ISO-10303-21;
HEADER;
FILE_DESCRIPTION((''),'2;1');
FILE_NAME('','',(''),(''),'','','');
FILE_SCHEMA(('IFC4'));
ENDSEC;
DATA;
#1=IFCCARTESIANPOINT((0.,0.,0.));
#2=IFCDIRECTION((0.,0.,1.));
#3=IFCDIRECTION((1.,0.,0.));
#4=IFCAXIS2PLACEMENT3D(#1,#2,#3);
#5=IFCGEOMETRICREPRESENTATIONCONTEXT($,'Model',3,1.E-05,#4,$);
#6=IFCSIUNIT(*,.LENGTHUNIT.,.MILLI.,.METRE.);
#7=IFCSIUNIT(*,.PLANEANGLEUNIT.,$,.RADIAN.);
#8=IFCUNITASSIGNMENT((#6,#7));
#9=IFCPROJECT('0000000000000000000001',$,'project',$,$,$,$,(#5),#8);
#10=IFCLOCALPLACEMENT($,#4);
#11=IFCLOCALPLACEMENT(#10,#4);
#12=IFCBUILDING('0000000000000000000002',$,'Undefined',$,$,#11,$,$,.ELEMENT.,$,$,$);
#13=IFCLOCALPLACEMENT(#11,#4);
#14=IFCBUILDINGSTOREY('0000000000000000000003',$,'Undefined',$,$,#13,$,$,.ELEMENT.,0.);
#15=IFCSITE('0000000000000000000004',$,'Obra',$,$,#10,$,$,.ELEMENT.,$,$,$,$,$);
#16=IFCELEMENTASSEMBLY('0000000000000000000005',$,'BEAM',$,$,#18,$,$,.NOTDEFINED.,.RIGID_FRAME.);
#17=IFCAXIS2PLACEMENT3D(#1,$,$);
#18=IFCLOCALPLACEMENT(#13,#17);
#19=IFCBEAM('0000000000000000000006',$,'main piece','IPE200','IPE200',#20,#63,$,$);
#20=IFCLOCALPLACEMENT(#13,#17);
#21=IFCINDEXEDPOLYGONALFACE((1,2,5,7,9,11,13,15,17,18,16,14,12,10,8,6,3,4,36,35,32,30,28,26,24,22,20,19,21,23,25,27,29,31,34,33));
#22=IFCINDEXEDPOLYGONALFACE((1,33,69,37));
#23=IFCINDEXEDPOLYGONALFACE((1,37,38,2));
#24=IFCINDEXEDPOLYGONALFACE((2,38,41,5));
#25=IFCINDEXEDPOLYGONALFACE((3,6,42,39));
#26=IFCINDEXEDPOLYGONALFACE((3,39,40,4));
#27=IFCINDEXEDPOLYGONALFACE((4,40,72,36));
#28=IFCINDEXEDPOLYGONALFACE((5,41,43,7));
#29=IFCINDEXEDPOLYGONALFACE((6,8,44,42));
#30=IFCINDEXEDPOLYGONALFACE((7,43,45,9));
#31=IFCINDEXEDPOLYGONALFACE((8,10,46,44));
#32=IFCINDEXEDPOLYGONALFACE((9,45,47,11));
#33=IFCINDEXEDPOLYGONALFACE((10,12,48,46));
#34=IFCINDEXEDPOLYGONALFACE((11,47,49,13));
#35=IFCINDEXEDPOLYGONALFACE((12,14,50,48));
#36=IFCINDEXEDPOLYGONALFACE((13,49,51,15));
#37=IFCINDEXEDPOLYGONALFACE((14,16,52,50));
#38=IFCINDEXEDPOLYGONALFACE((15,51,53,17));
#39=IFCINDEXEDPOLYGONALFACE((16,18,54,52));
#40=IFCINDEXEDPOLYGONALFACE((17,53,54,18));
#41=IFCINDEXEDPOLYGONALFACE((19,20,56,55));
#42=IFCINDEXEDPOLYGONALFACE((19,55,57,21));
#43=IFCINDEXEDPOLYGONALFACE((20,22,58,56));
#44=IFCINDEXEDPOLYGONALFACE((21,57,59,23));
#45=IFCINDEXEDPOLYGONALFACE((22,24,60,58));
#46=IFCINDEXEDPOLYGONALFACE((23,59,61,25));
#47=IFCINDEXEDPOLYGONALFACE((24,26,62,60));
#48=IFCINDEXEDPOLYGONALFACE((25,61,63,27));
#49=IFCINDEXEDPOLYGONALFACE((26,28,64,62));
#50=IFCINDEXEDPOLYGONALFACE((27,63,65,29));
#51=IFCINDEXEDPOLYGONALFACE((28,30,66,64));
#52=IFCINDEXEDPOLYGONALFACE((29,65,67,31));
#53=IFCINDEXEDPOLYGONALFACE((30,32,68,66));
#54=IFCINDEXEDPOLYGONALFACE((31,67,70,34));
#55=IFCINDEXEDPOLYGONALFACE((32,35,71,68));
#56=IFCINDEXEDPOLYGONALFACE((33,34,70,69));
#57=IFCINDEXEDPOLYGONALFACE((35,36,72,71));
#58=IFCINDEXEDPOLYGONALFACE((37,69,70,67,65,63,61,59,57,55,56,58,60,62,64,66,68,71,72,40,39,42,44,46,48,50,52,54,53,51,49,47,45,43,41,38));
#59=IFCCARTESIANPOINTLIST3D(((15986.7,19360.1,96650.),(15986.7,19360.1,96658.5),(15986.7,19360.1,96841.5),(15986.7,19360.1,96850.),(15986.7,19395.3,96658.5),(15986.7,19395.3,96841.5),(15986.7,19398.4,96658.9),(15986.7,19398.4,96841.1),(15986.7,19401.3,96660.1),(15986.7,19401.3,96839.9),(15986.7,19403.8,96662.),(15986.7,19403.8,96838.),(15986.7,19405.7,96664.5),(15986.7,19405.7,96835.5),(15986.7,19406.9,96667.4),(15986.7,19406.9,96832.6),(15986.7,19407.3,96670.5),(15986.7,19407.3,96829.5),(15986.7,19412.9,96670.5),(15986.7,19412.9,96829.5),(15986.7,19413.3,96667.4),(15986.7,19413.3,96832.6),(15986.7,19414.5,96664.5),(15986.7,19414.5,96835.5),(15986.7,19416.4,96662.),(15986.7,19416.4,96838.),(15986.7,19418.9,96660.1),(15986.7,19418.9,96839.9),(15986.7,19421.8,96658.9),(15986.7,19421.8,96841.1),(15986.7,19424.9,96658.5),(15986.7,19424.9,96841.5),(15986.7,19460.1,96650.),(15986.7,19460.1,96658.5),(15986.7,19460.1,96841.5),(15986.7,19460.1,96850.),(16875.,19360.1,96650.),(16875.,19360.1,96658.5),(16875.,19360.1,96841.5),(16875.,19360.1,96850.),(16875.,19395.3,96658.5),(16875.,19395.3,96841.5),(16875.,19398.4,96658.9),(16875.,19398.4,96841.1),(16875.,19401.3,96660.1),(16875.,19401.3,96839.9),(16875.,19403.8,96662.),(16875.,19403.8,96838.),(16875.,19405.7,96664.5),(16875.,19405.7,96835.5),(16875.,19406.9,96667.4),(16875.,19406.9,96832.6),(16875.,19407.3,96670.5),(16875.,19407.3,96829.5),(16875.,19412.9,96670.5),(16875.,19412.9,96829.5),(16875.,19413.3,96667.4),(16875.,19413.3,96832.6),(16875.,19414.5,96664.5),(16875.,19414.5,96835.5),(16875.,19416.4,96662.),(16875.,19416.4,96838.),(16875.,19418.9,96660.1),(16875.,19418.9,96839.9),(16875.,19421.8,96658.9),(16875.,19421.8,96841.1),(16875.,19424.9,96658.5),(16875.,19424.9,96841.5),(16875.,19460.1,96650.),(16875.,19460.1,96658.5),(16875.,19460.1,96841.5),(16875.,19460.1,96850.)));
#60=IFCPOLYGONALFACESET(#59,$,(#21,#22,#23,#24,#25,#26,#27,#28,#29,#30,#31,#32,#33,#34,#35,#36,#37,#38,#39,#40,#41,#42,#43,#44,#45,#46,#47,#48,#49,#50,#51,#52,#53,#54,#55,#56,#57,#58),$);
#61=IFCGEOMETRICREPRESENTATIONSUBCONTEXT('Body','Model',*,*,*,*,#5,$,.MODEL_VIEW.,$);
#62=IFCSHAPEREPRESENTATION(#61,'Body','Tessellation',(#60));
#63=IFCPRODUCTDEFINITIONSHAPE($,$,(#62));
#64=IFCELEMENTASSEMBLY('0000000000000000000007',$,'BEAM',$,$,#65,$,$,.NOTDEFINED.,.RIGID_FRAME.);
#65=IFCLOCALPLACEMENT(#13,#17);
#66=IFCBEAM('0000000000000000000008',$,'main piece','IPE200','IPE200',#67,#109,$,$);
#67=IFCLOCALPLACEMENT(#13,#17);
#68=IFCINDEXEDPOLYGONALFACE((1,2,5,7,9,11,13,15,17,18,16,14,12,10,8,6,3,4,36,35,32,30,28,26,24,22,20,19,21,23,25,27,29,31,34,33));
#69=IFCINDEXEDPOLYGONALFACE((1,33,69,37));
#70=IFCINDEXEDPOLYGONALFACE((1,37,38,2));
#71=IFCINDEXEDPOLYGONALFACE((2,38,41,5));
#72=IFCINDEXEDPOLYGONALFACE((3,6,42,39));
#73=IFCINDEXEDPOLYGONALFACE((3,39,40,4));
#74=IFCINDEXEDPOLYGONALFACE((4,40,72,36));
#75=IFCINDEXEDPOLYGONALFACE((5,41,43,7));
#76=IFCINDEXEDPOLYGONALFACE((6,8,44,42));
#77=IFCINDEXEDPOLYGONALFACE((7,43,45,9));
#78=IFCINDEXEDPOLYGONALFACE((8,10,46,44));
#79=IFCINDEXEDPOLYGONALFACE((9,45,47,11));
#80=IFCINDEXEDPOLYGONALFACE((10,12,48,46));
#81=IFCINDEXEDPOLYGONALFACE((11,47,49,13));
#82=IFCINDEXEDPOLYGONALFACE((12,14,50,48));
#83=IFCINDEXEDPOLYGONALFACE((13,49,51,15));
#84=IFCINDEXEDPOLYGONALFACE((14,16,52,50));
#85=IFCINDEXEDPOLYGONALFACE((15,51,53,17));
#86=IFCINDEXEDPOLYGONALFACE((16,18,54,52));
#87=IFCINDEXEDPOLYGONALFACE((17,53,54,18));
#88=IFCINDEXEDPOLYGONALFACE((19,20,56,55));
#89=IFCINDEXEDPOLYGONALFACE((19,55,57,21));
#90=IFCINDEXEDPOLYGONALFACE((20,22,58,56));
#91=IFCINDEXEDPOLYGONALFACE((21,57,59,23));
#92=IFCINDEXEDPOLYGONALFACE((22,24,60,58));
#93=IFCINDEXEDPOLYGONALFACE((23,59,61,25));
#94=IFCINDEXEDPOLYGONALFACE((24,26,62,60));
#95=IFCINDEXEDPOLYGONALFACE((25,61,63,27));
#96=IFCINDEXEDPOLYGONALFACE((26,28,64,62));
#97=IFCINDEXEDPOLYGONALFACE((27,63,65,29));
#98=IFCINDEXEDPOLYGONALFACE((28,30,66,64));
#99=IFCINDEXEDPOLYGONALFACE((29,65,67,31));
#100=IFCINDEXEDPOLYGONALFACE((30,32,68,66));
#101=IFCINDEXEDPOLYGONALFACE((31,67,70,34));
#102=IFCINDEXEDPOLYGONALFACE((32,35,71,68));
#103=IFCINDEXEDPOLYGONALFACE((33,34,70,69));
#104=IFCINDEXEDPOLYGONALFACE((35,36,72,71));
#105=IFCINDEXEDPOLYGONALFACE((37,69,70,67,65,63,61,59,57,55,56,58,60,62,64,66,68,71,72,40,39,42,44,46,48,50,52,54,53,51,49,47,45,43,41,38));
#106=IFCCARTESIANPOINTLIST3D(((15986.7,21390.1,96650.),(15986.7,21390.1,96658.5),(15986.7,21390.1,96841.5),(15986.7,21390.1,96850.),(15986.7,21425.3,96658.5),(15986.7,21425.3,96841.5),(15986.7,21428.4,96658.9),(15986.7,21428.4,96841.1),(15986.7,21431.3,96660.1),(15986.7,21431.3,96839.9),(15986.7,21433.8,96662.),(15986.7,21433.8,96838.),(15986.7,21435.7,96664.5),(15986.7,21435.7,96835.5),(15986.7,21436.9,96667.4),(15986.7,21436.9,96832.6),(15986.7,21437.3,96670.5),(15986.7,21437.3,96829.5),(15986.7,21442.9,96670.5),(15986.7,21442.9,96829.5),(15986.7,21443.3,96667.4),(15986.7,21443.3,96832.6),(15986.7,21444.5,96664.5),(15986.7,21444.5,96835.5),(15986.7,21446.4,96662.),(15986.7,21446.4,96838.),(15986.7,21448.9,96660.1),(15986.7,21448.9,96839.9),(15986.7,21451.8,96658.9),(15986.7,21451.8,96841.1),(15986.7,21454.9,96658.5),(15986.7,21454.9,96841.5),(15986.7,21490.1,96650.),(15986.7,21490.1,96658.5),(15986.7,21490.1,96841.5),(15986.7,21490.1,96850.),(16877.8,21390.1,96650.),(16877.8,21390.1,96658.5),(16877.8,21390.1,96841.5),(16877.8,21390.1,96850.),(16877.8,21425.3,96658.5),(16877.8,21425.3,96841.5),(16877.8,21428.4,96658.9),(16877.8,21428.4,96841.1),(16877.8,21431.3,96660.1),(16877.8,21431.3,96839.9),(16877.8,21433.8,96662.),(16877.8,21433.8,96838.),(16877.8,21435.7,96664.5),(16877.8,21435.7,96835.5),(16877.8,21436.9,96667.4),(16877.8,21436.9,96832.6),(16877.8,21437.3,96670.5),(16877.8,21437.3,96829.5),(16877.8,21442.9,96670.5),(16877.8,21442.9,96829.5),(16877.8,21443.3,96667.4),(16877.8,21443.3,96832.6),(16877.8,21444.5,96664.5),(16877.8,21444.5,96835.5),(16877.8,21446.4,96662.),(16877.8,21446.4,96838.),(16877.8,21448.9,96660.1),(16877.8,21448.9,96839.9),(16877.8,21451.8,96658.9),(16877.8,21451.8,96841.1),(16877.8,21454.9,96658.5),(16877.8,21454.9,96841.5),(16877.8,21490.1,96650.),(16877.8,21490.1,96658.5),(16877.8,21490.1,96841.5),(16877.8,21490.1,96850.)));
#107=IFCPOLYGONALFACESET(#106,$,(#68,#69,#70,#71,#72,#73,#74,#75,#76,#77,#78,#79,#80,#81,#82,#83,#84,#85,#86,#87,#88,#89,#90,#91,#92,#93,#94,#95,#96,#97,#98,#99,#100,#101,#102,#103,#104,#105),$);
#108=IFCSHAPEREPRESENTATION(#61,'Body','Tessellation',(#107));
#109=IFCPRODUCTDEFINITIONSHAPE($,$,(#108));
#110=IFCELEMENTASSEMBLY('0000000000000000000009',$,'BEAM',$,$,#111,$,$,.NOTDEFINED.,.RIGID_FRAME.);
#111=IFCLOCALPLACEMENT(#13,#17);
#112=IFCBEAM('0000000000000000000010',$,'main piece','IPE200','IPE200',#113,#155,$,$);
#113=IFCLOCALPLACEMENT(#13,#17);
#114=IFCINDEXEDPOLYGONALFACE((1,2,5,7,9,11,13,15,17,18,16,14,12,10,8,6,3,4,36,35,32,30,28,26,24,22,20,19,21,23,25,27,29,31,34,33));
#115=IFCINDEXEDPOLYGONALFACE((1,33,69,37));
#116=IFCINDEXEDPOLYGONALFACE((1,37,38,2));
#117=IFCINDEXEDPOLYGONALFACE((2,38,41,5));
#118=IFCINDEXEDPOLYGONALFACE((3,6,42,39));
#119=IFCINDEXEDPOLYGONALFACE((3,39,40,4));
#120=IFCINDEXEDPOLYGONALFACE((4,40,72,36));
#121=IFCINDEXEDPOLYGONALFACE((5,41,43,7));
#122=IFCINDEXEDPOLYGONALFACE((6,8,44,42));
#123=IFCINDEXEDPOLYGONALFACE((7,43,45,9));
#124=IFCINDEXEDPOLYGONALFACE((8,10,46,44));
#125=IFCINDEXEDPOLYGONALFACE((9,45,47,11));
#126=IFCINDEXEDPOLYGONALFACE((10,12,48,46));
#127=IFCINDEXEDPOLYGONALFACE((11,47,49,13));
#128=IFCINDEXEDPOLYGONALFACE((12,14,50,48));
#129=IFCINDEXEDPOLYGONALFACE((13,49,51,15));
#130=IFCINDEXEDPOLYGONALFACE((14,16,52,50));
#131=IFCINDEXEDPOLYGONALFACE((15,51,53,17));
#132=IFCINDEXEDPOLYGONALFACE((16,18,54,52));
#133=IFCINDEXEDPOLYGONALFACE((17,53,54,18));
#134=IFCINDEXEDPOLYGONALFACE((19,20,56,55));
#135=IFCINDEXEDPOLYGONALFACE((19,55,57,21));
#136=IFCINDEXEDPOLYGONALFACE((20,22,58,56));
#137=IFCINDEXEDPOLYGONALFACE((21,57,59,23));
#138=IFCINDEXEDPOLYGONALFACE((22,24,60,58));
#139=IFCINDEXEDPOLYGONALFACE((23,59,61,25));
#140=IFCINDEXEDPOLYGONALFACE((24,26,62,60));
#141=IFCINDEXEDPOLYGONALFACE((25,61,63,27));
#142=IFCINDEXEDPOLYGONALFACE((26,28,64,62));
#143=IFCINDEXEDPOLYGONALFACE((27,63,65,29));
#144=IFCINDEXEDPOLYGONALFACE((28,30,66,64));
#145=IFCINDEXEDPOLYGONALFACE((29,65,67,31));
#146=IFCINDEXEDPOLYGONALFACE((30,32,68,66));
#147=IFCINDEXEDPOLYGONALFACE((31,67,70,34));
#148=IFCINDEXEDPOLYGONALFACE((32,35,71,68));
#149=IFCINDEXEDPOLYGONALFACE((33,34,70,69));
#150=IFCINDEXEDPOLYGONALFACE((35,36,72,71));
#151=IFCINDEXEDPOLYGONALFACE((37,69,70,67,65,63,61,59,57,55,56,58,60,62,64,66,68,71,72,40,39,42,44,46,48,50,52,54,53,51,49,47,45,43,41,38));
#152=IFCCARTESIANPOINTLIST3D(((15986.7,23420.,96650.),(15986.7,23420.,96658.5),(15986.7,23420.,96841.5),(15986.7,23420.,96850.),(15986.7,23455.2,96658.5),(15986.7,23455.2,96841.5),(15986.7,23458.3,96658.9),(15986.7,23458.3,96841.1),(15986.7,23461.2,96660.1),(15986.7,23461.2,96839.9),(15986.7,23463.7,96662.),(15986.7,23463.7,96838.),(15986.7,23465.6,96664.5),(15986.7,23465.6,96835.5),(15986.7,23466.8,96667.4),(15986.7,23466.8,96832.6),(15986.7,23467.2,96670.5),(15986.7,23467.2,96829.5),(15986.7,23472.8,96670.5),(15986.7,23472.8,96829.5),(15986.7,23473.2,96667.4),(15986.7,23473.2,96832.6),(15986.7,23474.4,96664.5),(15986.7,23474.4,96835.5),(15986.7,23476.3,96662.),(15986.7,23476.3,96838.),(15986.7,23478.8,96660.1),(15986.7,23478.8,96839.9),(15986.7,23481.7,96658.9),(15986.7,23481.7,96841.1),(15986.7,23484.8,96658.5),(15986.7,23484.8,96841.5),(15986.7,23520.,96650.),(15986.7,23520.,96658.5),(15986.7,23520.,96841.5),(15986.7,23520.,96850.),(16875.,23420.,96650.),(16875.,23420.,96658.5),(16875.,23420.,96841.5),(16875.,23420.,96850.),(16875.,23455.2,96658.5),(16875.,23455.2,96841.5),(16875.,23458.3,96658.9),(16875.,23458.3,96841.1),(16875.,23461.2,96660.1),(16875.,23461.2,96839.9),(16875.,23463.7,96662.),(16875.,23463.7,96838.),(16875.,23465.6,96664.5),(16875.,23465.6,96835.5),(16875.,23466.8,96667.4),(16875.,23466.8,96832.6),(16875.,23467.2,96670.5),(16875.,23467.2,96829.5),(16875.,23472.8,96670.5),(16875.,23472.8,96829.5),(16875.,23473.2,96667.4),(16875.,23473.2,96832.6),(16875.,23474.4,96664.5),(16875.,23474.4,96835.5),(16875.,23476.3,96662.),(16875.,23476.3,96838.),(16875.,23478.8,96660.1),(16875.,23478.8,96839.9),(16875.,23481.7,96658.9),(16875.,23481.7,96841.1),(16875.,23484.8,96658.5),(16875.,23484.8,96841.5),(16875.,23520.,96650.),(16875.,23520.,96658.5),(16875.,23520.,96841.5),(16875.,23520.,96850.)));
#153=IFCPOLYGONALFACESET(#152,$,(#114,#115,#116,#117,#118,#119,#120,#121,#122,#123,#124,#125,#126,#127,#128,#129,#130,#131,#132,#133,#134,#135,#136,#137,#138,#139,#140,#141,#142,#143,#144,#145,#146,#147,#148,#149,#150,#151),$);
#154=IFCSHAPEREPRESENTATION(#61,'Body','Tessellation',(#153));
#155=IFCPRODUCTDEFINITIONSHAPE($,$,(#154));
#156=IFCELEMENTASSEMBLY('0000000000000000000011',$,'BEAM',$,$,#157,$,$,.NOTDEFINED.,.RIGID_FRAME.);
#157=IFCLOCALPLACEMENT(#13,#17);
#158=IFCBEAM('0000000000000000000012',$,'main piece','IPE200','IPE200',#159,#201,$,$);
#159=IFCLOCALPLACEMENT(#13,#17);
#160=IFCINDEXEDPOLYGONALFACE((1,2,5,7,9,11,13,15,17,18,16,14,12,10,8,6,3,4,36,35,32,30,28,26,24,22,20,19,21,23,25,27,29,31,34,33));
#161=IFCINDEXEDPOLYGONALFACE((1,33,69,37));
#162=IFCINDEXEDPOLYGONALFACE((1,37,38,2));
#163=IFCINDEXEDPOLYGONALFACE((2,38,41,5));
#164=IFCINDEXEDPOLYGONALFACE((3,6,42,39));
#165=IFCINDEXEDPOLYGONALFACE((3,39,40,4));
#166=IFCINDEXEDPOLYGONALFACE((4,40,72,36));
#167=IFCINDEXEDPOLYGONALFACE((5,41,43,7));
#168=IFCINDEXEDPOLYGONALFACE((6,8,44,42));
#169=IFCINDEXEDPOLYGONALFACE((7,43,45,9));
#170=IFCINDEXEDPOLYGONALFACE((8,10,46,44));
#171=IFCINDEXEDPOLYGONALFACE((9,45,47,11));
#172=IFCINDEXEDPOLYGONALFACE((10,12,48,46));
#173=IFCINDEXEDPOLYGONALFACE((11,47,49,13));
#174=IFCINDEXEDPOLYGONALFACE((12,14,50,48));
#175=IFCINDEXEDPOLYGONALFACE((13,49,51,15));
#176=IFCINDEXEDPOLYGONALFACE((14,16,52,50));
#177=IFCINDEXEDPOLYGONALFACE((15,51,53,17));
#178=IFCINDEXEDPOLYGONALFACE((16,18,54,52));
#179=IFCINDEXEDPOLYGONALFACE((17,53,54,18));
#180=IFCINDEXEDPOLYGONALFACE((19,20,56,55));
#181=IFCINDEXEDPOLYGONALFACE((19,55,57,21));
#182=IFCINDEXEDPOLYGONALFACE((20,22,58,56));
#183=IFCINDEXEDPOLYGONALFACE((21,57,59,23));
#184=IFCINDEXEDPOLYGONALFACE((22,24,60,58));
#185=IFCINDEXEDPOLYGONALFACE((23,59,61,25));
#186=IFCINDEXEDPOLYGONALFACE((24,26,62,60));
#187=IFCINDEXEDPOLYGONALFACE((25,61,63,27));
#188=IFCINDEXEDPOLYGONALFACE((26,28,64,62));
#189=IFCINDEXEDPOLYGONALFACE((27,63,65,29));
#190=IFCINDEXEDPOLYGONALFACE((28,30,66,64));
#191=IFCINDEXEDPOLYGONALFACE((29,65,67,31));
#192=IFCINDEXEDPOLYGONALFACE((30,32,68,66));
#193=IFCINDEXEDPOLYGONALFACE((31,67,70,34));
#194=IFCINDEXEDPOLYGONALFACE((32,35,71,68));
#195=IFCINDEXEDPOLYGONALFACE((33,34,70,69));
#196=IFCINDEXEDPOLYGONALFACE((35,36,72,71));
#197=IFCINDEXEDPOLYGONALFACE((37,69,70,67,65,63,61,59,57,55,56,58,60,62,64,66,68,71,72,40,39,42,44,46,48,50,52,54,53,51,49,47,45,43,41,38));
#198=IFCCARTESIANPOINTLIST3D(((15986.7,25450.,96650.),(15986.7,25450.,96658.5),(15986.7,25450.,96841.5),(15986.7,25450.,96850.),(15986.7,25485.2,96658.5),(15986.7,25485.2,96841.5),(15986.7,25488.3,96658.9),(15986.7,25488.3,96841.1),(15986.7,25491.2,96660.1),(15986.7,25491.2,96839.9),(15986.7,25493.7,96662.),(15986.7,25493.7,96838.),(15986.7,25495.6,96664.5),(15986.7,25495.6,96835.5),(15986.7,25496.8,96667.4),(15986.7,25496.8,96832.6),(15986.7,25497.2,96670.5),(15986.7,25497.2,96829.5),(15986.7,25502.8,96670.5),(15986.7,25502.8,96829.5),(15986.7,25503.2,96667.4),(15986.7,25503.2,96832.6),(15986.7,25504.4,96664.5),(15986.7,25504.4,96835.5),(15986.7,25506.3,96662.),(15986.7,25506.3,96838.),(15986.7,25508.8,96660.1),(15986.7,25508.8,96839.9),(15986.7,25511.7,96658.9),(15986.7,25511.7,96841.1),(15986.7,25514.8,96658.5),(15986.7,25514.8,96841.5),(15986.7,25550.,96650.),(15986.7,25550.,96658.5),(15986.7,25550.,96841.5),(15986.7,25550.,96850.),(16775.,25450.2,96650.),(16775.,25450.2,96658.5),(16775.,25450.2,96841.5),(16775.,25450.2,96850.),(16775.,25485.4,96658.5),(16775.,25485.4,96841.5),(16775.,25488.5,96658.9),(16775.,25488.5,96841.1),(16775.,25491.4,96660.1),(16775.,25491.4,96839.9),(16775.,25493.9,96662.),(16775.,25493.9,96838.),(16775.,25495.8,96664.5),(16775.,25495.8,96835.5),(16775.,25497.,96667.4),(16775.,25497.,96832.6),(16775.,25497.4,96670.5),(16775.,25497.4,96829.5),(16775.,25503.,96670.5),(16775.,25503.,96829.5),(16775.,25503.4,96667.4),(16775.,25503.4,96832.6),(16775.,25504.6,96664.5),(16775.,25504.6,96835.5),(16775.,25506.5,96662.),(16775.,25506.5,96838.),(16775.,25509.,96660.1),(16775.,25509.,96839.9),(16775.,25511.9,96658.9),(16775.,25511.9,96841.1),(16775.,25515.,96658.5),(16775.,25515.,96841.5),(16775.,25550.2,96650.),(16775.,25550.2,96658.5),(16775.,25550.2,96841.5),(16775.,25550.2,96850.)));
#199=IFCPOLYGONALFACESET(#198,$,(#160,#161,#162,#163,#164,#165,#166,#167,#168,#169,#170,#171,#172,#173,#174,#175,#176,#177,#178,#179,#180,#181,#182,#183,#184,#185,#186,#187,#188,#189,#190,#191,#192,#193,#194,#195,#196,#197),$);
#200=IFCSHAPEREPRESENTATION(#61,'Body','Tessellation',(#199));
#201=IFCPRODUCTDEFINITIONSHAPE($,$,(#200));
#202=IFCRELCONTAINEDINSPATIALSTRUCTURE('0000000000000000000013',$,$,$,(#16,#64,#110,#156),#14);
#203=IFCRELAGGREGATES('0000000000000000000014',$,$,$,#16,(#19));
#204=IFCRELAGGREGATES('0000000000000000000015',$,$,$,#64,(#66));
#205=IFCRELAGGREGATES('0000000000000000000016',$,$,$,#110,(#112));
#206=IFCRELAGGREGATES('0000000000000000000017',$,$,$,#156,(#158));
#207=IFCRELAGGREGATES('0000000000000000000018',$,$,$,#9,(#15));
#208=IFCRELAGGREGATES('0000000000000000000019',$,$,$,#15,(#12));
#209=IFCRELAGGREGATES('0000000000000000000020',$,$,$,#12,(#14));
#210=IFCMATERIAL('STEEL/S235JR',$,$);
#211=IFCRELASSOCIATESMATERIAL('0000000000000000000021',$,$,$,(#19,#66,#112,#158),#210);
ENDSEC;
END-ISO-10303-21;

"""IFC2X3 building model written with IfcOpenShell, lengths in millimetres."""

from ifc_helpers import new_model, si_unit, frame, origin_with_axes, origin_2d_with_axis, place, context, subcontext, project, spatial, i_section, extrude, material, element, aggregate, save


model = new_model("IFC2X3")

# Units and contexts
model_context = context("Model", 3, precision=1e-05, world=origin_with_axes())
body_context = subcontext(model_context, "Body", "Model", "MODEL_VIEW")
ifc_project = project(units=[si_unit("LENGTHUNIT", "METRE", prefix="MILLI"), si_unit("PLANEANGLEUNIT", "RADIAN")], contexts=[model_context])

# Site, building, storey
site_placement = place(None, origin_with_axes())
site = spatial("IfcSite", under=ifc_project, at=site_placement, Name="Obra", CompositionType="ELEMENT")
building_placement = place(site_placement, origin_with_axes())
building = spatial("IfcBuilding", under=site, at=building_placement, Name="Undefined", CompositionType="ELEMENT")
storey_placement = place(building_placement, origin_with_axes())
storey = spatial("IfcBuildingStorey", under=building, at=storey_placement, Name="Undefined", CompositionType="ELEMENT", Elevation=0.0)

# Element assemblies, beams
ifc_material = material(Name="STEEL/S235JR")
assembly_1_placement = place(storey_placement, origin_with_axes())
assembly_1 = element("IfcElementAssembly", 1, at=assembly_1_placement, inside=storey, Name="BEAM", AssemblyPlace="NOTDEFINED", PredefinedType="RIGID_FRAME")
beam_1_placement = place(assembly_1_placement, frame((15986.7, 19410.1, 96750.0), z_axis=(0.0, 0.0, 1.0), x_axis=(1.0, 0.0, 0.0)))
beam_1 = element("IfcBeam", 2, at=beam_1_placement, material=ifc_material, Name="main piece", Description="IPE200", ObjectType="IPE200", context=body_context, shape_type="SweptSolid", body=[
    extrude(i_section(OverallWidth=100.0, OverallDepth=200.0, WebThickness=5.6, FlangeThickness=8.5, FilletRadius=12.0, at=origin_2d_with_axis()), frame((888.3, 0.0, 0.0), z_axis=(-1.0, 0.0, 0.0), x_axis=(0.0, -1.0, 0.0)), (0.0, 0.0, 1.0), 888.3),
])
aggregate(assembly_1, [beam_1])
assembly_2_placement = place(storey_placement, origin_with_axes())
assembly_2 = element("IfcElementAssembly", 3, at=assembly_2_placement, inside=storey, Name="BEAM", AssemblyPlace="NOTDEFINED", PredefinedType="RIGID_FRAME")
beam_2_placement = place(assembly_2_placement, frame((16877.8, 21440.1, 96750.0), z_axis=(0.0, 0.0, 1.0), x_axis=(-1.0, -0.000037, 0.0)))
beam_2 = element("IfcBeam", 4, at=beam_2_placement, material=ifc_material, Name="main piece", Description="IPE200", ObjectType="IPE200", context=body_context, shape_type="SweptSolid", body=[
    extrude(i_section(OverallWidth=100.0, OverallDepth=200.0, WebThickness=5.6, FlangeThickness=8.5, FilletRadius=12.0, at=origin_2d_with_axis()), frame((891.1, 0.0, 0.0), z_axis=(-1.0, 0.0, 0.0), x_axis=(0.0, -1.0, 0.0)), (0.0, 0.0, 1.0), 891.1),
])
aggregate(assembly_2, [beam_2])
assembly_3_placement = place(storey_placement, origin_with_axes())
assembly_3 = element("IfcElementAssembly", 5, at=assembly_3_placement, inside=storey, Name="BEAM", AssemblyPlace="NOTDEFINED", PredefinedType="RIGID_FRAME")
beam_3_placement = place(assembly_3_placement, frame((15986.7, 23470.0, 96750.0), z_axis=(0.0, 0.0, 1.0), x_axis=(1.0, 0.0, 0.0)))
beam_3 = element("IfcBeam", 6, at=beam_3_placement, material=ifc_material, Name="main piece", Description="IPE200", ObjectType="IPE200", context=body_context, shape_type="SweptSolid", body=[
    extrude(i_section(OverallWidth=100.0, OverallDepth=200.0, WebThickness=5.6, FlangeThickness=8.5, FilletRadius=12.0, at=origin_2d_with_axis()), frame((888.3, 0.0, 0.0), z_axis=(-1.0, 0.0, 0.0), x_axis=(0.0, -1.0, 0.0)), (0.0, 0.0, 1.0), 888.3),
])
aggregate(assembly_3, [beam_3])
assembly_4_placement = place(storey_placement, origin_with_axes())
assembly_4 = element("IfcElementAssembly", 7, at=assembly_4_placement, inside=storey, Name="BEAM", AssemblyPlace="NOTDEFINED", PredefinedType="RIGID_FRAME")
beam_4_placement = place(assembly_4_placement, frame((16775.0, 25500.2, 96750.0), z_axis=(0.0, 0.0, 1.0), x_axis=(-1.0, -0.000266, 0.0)))
beam_4 = element("IfcBeam", 8, at=beam_4_placement, material=ifc_material, Name="main piece", Description="IPE200", ObjectType="IPE200", context=body_context, shape_type="SweptSolid", body=[
    extrude(i_section(OverallWidth=100.0, OverallDepth=200.0, WebThickness=5.6, FlangeThickness=8.5, FilletRadius=12.0, at=origin_2d_with_axis()), frame((788.3, 0.0, 0.0), z_axis=(-1.0, 0.0, 0.0), x_axis=(0.0, -1.0, 0.0)), (0.0, 0.0, 1.0), 788.3),
])
aggregate(assembly_4, [beam_4])

save(model, "model.ifc")
